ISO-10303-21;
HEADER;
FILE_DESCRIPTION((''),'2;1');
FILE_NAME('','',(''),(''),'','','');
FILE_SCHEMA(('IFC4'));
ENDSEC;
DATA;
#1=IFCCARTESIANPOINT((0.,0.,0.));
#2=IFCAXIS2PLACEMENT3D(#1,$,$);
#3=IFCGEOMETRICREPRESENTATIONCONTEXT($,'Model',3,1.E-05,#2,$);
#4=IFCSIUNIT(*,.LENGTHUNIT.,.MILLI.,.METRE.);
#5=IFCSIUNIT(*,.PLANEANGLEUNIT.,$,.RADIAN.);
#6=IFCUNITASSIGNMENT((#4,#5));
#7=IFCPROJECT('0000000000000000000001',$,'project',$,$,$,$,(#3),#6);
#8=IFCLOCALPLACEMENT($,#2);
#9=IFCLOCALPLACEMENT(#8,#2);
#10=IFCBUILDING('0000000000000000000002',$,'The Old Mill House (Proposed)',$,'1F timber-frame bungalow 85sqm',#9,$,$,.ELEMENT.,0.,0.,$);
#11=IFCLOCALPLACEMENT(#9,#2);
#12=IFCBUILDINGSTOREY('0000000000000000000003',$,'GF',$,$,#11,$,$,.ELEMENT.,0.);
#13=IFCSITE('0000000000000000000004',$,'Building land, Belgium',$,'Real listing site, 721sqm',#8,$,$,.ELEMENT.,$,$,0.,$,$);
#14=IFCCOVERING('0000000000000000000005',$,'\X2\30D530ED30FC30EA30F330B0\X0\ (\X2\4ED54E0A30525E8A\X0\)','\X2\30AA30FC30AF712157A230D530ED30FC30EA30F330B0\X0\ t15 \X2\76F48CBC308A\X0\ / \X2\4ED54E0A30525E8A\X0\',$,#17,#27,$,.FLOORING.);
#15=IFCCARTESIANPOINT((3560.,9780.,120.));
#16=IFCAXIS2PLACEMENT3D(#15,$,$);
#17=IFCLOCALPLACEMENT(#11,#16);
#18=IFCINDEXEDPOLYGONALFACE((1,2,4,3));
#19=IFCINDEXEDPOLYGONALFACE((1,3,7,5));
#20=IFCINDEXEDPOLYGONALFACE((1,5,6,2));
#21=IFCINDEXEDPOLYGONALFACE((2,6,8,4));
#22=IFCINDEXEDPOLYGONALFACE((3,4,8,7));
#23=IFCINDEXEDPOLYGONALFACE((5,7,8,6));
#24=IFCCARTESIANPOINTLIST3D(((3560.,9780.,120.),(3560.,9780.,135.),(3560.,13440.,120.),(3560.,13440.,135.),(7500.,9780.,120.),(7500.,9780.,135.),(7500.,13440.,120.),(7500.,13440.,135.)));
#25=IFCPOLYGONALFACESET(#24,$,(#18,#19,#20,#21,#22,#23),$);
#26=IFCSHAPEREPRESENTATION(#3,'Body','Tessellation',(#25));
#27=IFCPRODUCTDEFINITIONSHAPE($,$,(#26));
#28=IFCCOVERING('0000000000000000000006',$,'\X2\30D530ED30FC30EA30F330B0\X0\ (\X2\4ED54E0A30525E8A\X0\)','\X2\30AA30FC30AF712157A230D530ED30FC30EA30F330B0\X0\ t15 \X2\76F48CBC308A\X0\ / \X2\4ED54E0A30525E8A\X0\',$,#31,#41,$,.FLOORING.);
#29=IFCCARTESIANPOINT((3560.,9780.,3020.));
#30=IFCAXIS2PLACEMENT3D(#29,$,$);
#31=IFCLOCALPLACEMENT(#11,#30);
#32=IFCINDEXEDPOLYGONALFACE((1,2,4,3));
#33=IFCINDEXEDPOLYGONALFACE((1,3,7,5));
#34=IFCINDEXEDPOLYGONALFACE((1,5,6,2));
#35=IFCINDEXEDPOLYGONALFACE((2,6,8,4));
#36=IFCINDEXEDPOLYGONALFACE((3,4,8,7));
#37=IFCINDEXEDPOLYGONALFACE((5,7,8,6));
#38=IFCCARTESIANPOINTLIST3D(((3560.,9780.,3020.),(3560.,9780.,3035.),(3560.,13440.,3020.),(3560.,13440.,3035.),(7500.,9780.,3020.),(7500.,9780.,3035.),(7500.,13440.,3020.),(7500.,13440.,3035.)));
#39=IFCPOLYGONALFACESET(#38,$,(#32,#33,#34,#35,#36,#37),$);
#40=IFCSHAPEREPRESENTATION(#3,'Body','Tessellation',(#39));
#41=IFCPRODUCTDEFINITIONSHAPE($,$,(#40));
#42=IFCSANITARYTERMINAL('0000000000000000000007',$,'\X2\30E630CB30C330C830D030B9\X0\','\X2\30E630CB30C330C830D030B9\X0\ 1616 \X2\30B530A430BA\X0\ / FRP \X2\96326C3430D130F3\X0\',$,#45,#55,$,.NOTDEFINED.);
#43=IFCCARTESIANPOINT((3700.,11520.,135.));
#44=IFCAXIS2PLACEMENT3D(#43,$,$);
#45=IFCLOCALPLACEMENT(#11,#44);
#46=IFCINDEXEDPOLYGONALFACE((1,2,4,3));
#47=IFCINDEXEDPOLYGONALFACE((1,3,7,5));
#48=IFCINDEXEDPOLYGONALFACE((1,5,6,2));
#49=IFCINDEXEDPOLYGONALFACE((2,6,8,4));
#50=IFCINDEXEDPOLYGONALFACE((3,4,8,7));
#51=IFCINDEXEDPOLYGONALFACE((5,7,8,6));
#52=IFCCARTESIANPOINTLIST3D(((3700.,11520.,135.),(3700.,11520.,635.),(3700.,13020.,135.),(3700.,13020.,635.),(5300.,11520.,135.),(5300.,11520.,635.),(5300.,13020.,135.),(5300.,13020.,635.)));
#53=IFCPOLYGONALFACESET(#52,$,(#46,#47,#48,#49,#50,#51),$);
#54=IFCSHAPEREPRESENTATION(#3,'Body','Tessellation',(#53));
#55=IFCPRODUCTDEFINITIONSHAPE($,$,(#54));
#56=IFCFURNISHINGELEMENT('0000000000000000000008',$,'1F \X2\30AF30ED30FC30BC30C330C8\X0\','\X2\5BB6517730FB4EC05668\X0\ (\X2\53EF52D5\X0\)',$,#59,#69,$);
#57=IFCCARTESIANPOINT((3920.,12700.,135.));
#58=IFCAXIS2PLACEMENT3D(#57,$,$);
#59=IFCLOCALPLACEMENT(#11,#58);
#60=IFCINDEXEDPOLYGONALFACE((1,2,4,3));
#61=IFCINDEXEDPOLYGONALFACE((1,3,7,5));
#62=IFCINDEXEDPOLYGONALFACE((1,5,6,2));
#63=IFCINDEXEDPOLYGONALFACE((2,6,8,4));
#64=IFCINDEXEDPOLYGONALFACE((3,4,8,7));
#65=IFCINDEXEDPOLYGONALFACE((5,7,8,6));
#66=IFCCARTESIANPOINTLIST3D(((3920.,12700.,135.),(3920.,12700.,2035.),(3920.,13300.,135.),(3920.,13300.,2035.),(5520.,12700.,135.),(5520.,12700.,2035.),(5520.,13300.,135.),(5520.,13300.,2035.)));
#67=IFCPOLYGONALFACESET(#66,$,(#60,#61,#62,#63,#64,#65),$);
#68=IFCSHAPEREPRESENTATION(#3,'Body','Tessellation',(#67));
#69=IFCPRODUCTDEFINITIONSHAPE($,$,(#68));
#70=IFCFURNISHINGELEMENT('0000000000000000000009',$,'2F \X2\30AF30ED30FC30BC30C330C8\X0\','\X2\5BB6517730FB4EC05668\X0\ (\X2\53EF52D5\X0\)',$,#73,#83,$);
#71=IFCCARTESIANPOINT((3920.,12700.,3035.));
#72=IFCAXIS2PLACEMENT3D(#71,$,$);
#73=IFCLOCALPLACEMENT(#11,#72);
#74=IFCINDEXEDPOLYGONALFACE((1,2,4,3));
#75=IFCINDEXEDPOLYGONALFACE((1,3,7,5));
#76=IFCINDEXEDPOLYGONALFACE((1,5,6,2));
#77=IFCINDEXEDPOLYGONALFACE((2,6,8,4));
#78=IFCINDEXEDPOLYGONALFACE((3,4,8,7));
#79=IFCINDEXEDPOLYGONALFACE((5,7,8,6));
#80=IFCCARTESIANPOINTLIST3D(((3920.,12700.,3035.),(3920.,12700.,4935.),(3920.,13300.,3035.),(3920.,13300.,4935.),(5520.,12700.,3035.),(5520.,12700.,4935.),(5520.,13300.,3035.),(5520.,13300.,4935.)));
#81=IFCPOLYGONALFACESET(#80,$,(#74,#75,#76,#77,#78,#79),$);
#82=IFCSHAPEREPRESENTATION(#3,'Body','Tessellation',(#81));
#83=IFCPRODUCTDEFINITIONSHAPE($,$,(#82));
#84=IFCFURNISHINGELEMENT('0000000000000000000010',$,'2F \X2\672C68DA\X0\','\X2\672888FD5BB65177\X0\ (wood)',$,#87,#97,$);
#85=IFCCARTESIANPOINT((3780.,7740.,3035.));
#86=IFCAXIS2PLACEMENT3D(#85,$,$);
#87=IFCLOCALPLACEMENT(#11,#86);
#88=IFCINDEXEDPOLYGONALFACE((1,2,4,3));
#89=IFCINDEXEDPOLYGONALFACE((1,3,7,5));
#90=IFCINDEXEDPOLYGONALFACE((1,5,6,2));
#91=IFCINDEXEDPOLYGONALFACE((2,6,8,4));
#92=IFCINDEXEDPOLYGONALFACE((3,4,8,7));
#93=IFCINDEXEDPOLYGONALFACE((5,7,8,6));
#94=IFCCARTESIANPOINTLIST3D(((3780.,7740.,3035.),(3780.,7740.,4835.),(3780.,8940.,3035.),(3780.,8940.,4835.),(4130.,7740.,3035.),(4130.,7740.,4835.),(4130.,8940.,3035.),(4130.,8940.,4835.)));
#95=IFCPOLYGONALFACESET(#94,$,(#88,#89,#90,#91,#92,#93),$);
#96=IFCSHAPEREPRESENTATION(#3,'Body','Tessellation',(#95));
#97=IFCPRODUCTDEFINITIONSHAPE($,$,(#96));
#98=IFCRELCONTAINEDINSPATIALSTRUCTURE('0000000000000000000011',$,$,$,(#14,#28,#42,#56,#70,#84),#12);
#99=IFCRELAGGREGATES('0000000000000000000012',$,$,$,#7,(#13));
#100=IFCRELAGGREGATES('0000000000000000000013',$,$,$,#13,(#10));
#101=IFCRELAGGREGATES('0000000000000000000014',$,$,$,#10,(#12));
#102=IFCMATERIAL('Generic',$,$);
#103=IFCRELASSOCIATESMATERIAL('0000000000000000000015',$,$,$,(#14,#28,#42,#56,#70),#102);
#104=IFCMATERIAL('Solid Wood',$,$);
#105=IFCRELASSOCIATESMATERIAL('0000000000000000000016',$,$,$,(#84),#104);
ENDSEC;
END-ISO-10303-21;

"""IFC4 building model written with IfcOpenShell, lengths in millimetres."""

from ifc_helpers import new_model, si_unit, frame, frame_2d, origin, place, context, project, spatial, rectangle, extrude, material, element, save


model = new_model("IFC4")

# Units and contexts
model_context = context("Model", 3, precision=1e-05, world=origin())
ifc_project = project(units=[si_unit("LENGTHUNIT", "METRE", prefix="MILLI"), si_unit("PLANEANGLEUNIT", "RADIAN")], contexts=[model_context])

# Site, building, storey
site_placement = place(None, origin())
site = spatial("IfcSite", under=ifc_project, at=site_placement, Name="Building land, Belgium", ObjectType="Real listing site, 721sqm", CompositionType="ELEMENT", RefElevation=0.0)
building_placement = place(site_placement, origin())
building = spatial("IfcBuilding", under=site, at=building_placement, Name="The Old Mill House (Proposed)", ObjectType="1F timber-frame bungalow 85sqm", CompositionType="ELEMENT", ElevationOfRefHeight=0.0, ElevationOfTerrain=0.0)
storey_placement = place(building_placement, origin())
storey = spatial("IfcBuildingStorey", under=building, at=storey_placement, Name="GF", CompositionType="ELEMENT", Elevation=0.0)

# Shared definitions
ifc_material_1 = material(Name="Solid Wood")

# Coverings
ifc_material_2 = material(Name="Generic")
covering_1_placement = place(storey_placement, frame((3560.0, 9780.0, 120.0)))
element("IfcCovering", 1, at=covering_1_placement, inside=storey, material=ifc_material_2, Name="フローリング (仕上げ床)", Description="オーク無垢フローリング t15 直貼り / 仕上げ床", PredefinedType="FLOORING", context=model_context, shape_type="SweptSolid", body=[
    extrude(rectangle(XDim=3940.0, YDim=3660.0, at=frame_2d((1970.0, 1830.0))), frame((3560.0, 9780.0, 120.0)), (0.0, 0.0, 1.0), 15.0),
])
covering_2_placement = place(storey_placement, frame((3560.0, 9780.0, 3020.0)))
element("IfcCovering", 2, at=covering_2_placement, inside=storey, material=ifc_material_2, Name="フローリング (仕上げ床)", Description="オーク無垢フローリング t15 直貼り / 仕上げ床", PredefinedType="FLOORING", context=model_context, shape_type="SweptSolid", body=[
    extrude(rectangle(XDim=3940.0, YDim=3660.0, at=frame_2d((1970.0, 1830.0))), frame((3560.0, 9780.0, 3020.0)), (0.0, 0.0, 1.0), 15.0),
])

# Sanitary terminal
sanitary_terminal_placement = place(storey_placement, frame((3700.0, 11520.0, 135.0)))
element("IfcSanitaryTerminal", 3, at=sanitary_terminal_placement, inside=storey, material=ifc_material_2, Name="ユニットバス", Description="ユニットバス 1616 サイズ / FRP 防水パン", PredefinedType="NOTDEFINED", context=model_context, shape_type="SweptSolid", body=[
    extrude(rectangle(XDim=1600.0, YDim=1500.0, at=frame_2d((800.0, 750.0))), frame((3700.0, 11520.0, 135.0)), (0.0, 0.0, 1.0), 500.0),
])

# Furnishing elements
furnishing_1_placement = place(storey_placement, frame((3920.0, 12700.0, 135.0)))
element("IfcFurnishingElement", 4, at=furnishing_1_placement, inside=storey, material=ifc_material_2, Name="1F クローゼット", Description="家具・什器 (可動)", context=model_context, shape_type="SweptSolid", body=[
    extrude(rectangle(XDim=1600.0, YDim=600.0, at=frame_2d((800.0, 300.0))), frame((3920.0, 12700.0, 135.0)), (0.0, 0.0, 1.0), 1900.0),
])
furnishing_2_placement = place(storey_placement, frame((3920.0, 12700.0, 3035.0)))
element("IfcFurnishingElement", 5, at=furnishing_2_placement, inside=storey, material=ifc_material_2, Name="2F クローゼット", Description="家具・什器 (可動)", context=model_context, shape_type="SweptSolid", body=[
    extrude(rectangle(XDim=1600.0, YDim=600.0, at=frame_2d((800.0, 300.0))), frame((3920.0, 12700.0, 3035.0)), (0.0, 0.0, 1.0), 1900.0),
])
furnishing_3_placement = place(storey_placement, frame((3780.0, 7740.0, 3035.0)))
element("IfcFurnishingElement", 6, at=furnishing_3_placement, inside=storey, material=ifc_material_1, Name="2F 本棚", Description="木製家具 (wood)", context=model_context, shape_type="SweptSolid", body=[
    extrude(rectangle(XDim=350.0, YDim=1200.0, at=frame_2d((175.0, 600.0))), frame((3780.0, 7740.0, 3035.0)), (0.0, 0.0, 1.0), 1800.0),
])

save(model, "model.ifc")
